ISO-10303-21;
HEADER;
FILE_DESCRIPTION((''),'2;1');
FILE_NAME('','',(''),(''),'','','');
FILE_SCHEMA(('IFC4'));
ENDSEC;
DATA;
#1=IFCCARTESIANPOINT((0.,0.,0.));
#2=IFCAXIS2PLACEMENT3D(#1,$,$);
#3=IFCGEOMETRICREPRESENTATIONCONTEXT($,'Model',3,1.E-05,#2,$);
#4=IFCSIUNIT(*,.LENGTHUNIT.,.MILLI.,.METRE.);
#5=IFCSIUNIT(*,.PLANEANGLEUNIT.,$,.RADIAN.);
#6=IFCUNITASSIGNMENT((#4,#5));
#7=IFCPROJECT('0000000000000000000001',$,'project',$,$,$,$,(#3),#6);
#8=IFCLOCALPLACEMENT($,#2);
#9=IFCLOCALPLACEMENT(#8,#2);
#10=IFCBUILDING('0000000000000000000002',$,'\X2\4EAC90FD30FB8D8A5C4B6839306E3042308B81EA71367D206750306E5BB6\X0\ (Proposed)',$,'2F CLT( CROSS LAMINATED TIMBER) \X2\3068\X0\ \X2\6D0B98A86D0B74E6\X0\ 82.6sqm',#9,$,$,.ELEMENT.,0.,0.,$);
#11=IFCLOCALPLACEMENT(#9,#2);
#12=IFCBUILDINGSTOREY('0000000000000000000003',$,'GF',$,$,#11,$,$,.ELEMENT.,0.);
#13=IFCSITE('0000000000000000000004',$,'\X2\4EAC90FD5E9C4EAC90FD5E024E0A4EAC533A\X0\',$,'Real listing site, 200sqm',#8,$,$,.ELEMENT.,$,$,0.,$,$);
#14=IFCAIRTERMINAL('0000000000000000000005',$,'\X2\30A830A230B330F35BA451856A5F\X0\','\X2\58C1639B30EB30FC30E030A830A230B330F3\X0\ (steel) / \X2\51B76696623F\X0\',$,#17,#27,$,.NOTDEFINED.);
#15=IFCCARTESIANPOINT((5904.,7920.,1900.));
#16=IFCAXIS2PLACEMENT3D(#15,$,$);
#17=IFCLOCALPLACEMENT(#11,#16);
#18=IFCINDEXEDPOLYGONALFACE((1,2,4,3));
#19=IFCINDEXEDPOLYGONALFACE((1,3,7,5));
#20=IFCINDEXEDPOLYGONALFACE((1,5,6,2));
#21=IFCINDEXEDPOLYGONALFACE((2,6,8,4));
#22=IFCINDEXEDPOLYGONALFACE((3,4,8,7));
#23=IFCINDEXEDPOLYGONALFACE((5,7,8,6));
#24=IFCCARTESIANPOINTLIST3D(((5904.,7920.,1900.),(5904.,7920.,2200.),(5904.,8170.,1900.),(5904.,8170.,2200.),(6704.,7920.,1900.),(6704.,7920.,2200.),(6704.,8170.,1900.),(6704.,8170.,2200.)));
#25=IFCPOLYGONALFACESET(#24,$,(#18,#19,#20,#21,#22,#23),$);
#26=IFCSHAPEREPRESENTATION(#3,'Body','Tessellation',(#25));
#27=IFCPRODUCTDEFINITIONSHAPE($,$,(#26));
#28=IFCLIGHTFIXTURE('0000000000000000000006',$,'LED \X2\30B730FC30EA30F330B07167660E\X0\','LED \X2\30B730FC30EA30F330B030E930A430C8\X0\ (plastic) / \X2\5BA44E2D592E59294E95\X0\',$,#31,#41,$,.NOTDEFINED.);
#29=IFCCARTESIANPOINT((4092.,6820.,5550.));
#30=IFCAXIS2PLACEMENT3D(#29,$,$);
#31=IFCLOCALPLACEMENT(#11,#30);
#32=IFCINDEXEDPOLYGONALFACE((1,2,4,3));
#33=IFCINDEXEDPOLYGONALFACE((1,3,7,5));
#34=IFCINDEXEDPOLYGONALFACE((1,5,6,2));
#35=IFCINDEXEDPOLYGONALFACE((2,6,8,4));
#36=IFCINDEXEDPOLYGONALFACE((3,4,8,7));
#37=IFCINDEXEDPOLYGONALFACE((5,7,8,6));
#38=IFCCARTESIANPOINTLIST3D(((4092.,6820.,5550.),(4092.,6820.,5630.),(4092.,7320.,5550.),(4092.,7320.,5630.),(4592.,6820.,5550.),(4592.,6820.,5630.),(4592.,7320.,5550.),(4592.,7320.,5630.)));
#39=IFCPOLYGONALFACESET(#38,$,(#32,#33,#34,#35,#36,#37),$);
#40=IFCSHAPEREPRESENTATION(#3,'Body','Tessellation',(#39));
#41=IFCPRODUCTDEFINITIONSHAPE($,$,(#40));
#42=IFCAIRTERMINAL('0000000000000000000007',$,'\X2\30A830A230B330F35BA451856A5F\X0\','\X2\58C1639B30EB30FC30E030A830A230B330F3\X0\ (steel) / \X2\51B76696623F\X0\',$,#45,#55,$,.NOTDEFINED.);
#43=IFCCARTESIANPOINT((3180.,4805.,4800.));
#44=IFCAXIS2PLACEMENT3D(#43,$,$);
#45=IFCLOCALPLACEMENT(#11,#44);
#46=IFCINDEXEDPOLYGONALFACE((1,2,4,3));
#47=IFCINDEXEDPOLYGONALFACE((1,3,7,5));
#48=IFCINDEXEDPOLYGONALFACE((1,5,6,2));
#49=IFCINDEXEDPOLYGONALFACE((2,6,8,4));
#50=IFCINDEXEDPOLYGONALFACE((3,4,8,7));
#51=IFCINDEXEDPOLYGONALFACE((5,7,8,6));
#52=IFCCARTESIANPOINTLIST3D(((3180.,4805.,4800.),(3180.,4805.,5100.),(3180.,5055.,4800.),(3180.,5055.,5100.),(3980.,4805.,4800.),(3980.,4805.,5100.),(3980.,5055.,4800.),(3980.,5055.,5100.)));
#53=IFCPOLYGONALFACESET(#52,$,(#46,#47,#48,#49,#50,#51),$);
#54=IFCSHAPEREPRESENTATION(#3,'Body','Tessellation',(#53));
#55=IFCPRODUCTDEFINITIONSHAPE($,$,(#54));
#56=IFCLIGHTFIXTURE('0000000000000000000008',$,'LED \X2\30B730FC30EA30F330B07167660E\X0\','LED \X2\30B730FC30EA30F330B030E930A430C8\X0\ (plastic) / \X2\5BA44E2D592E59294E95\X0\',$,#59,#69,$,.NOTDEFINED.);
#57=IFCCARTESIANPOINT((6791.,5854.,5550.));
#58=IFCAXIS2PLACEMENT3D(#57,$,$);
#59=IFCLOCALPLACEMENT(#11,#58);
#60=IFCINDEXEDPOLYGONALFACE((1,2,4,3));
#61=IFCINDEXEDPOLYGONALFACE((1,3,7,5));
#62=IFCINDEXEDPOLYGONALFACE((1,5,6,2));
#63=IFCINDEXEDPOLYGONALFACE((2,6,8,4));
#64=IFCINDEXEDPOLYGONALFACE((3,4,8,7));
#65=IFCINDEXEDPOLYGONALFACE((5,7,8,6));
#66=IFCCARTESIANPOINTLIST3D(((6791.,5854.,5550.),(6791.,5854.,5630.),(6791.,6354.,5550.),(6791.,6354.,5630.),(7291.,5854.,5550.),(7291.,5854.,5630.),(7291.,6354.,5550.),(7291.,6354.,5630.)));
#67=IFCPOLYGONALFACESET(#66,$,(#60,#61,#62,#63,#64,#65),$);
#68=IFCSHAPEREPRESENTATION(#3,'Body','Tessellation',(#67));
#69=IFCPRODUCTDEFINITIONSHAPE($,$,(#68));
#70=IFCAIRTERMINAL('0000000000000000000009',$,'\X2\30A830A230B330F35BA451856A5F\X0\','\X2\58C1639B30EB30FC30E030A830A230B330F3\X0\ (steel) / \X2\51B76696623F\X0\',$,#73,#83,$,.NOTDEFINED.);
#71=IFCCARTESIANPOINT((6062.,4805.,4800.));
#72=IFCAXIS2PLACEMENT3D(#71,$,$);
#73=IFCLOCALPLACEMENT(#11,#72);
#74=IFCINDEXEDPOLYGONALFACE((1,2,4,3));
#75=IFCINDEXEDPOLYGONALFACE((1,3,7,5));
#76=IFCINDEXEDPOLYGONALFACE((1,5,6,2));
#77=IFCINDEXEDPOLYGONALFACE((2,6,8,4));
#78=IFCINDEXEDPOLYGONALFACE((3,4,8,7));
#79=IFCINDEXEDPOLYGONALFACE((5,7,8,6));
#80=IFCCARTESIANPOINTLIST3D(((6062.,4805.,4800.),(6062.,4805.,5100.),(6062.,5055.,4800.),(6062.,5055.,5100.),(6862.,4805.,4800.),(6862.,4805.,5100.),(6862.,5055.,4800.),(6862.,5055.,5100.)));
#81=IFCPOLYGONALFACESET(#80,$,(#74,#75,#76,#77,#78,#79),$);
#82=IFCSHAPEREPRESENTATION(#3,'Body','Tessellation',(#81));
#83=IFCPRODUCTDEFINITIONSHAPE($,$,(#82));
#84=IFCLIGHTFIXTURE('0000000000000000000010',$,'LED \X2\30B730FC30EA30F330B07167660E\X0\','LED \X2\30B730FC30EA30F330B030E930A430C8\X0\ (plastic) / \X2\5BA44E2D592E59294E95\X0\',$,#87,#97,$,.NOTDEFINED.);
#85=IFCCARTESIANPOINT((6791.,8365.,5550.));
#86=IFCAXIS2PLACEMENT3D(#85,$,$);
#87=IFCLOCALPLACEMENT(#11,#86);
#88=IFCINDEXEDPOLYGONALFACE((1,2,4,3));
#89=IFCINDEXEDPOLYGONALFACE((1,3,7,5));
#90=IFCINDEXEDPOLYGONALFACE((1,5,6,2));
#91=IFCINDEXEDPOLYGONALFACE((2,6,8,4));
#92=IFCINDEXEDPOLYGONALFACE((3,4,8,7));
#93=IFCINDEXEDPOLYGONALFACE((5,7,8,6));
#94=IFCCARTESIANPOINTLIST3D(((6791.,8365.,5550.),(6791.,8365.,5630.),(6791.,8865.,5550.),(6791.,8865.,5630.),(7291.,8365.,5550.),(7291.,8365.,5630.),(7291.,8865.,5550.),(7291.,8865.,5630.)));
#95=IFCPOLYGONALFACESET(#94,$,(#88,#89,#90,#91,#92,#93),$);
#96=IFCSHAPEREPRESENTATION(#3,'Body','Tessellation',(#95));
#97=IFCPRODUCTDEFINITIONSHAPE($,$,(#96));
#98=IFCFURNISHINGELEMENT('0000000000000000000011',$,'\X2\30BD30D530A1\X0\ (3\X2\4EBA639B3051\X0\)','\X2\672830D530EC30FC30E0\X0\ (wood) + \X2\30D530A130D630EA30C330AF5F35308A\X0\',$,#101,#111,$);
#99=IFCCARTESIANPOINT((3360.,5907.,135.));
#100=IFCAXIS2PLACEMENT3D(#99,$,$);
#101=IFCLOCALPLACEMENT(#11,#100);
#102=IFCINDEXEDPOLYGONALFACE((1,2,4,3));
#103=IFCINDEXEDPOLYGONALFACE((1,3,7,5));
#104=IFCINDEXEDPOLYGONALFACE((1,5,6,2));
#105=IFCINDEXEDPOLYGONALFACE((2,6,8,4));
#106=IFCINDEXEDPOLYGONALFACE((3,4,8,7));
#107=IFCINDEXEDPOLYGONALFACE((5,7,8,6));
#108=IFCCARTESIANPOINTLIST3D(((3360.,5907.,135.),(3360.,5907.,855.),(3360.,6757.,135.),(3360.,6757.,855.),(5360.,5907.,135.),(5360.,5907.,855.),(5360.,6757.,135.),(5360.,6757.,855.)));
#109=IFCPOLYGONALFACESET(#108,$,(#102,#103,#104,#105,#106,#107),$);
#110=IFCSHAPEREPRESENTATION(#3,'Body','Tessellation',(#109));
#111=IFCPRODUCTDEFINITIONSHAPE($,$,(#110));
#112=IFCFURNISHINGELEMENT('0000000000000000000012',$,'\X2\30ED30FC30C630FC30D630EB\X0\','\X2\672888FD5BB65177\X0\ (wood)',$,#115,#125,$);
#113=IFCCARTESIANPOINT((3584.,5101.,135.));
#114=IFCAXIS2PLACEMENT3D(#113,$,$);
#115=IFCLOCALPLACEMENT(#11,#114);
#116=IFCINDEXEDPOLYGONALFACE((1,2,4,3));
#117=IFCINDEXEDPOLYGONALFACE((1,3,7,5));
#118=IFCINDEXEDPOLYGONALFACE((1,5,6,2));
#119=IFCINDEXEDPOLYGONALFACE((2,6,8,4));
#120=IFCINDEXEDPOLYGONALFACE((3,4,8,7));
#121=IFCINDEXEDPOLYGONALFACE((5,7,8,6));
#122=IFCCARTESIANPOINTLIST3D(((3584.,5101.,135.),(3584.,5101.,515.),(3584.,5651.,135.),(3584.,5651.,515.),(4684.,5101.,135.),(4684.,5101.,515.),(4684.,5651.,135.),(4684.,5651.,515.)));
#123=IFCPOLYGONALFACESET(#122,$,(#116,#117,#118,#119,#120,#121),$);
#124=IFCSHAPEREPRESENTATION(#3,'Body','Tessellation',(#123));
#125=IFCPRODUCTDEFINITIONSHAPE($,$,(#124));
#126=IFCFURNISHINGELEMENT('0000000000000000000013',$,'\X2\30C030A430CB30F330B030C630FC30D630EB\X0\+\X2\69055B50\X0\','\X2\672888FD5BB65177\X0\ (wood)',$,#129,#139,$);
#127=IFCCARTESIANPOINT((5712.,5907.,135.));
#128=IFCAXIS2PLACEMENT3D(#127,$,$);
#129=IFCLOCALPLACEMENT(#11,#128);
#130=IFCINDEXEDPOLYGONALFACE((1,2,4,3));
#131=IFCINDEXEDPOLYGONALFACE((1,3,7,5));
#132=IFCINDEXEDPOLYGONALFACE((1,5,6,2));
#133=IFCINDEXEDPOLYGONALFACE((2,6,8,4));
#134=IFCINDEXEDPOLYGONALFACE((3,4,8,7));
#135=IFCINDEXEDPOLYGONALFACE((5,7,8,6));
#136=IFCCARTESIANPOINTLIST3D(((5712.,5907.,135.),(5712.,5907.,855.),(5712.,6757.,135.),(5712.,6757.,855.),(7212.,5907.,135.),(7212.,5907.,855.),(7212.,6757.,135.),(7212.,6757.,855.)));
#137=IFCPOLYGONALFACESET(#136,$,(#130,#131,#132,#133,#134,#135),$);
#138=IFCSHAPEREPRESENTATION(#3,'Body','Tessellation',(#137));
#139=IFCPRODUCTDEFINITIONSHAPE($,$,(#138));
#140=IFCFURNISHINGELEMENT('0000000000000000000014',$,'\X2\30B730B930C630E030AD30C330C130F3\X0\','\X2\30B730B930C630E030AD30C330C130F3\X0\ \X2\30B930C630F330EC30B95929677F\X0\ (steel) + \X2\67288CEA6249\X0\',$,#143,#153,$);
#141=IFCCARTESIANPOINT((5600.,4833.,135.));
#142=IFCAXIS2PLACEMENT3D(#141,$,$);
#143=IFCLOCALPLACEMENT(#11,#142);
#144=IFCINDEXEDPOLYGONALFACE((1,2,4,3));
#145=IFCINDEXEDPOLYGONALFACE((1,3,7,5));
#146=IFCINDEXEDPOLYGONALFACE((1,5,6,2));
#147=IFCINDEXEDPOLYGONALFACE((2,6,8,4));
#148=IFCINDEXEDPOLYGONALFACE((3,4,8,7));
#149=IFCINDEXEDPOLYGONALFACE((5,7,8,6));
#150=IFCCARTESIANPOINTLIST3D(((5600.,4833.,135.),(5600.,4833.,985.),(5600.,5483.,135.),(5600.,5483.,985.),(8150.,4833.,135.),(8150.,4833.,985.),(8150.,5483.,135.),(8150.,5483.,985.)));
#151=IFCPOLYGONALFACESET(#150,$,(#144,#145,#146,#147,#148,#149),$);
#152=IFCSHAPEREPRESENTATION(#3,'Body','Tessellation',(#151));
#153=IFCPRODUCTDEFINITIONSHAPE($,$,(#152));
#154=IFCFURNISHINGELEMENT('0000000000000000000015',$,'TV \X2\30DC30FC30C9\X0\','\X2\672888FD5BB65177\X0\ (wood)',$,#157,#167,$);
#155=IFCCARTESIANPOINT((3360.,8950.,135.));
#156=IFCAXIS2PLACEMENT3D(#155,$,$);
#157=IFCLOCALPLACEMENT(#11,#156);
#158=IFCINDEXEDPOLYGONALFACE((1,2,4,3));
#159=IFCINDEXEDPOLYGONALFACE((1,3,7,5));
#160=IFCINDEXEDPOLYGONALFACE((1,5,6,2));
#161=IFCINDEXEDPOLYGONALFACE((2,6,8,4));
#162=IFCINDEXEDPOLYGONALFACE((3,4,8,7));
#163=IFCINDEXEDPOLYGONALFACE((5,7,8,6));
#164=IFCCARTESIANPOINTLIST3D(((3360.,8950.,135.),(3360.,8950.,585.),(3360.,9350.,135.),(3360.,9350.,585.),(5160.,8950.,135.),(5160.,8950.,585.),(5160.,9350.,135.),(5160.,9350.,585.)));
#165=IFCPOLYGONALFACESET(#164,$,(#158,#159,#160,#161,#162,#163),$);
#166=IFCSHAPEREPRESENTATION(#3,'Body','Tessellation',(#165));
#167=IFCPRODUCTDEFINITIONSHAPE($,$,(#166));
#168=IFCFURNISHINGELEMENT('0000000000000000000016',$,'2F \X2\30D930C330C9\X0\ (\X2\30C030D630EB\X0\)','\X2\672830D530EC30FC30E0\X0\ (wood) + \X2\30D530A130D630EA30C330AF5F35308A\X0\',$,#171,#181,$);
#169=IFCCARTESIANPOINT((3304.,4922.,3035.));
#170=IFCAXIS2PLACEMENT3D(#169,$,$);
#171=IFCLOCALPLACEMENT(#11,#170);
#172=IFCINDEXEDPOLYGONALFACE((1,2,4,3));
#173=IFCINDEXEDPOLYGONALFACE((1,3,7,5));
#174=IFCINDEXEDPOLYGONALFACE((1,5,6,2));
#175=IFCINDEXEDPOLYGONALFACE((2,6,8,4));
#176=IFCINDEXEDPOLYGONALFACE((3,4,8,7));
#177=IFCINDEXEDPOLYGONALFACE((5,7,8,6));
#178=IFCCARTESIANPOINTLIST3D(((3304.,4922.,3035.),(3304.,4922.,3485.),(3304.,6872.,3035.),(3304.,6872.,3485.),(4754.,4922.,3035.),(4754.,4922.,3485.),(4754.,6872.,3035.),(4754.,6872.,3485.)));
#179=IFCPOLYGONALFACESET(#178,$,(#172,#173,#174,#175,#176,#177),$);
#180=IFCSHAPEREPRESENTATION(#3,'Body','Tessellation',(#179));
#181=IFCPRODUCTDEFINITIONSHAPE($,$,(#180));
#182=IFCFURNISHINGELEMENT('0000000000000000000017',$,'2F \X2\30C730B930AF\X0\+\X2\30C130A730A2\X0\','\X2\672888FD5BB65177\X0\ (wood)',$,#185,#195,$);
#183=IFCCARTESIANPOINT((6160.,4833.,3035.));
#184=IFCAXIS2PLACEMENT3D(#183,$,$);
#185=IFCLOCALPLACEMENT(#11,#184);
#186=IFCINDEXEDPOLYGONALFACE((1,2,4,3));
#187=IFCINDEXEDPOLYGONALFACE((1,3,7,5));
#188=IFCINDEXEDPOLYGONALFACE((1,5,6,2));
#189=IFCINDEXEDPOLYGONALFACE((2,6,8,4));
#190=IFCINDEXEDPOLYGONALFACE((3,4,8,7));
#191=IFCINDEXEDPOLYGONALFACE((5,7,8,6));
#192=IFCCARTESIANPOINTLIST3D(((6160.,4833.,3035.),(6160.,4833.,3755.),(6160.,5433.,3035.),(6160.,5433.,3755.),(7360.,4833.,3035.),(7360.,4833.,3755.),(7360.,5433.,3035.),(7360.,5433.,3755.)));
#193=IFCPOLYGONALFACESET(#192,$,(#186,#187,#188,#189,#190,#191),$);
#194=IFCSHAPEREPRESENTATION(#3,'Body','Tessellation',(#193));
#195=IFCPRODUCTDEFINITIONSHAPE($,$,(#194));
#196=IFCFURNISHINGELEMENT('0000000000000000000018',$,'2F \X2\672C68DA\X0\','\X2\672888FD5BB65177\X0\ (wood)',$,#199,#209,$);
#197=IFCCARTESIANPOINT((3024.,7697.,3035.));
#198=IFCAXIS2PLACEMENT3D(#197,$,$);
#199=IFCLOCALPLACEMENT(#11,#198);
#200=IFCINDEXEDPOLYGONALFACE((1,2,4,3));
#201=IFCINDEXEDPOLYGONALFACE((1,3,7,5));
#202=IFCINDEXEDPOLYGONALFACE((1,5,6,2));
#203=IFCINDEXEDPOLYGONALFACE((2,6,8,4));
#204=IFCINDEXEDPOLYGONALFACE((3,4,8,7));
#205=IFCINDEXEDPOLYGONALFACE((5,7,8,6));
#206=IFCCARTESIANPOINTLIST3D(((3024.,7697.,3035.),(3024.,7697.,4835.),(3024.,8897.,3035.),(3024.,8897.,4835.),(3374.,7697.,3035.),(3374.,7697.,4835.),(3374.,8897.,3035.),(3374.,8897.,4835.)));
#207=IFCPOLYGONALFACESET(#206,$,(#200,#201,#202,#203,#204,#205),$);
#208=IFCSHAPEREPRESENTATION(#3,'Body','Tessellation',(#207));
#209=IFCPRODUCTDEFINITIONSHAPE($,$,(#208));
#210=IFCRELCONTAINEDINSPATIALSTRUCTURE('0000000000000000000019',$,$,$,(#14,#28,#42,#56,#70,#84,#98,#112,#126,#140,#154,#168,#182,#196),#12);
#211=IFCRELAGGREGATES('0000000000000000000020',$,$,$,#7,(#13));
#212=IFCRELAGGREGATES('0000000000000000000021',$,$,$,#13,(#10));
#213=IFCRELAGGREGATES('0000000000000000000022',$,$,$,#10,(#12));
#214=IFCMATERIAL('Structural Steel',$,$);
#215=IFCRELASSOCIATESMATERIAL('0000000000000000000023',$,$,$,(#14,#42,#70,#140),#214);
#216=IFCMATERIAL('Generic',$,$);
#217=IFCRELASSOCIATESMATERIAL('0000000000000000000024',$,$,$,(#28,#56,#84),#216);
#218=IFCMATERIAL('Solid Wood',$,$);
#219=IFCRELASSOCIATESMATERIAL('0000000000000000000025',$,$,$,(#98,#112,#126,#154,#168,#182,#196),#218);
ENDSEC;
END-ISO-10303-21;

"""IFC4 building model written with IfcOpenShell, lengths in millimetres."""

from ifc_helpers import new_model, si_unit, frame, frame_2d, origin, place, context, project, spatial, rectangle, extrude, material, element, save


model = new_model("IFC4")

# Units and contexts
model_context = context("Model", 3, precision=1e-05, world=origin())
ifc_project = project(units=[si_unit("LENGTHUNIT", "METRE", prefix="MILLI"), si_unit("PLANEANGLEUNIT", "RADIAN")], contexts=[model_context])

# Site, building, storey
site_placement = place(None, origin())
site = spatial("IfcSite", under=ifc_project, at=site_placement, Name="京都府京都市上京区", ObjectType="Real listing site, 200sqm", CompositionType="ELEMENT", RefElevation=0.0)
building_placement = place(site_placement, origin())
building = spatial("IfcBuilding", under=site, at=building_placement, Name="京都・越屋根のある自然素材の家 (Proposed)", ObjectType="2F CLT( CROSS LAMINATED TIMBER) と 洋風洋瓦 82.6sqm", CompositionType="ELEMENT", ElevationOfRefHeight=0.0, ElevationOfTerrain=0.0)
storey_placement = place(building_placement, origin())
storey = spatial("IfcBuildingStorey", under=building, at=storey_placement, Name="GF", CompositionType="ELEMENT", Elevation=0.0)

# Shared definitions
ifc_material_1 = material(Name="Solid Wood")

# Shared definitions
ifc_material_2 = material(Name="Structural Steel")

# Shared definitions
ifc_material_3 = material(Name="Generic")

# Air terminal
air_terminal_1_placement = place(storey_placement, frame((5904.0, 7920.0, 1900.0)))
element("IfcAirTerminal", 1, at=air_terminal_1_placement, inside=storey, material=ifc_material_2, Name="エアコン室内機", Description="壁掛ルームエアコン (steel) / 冷暖房", PredefinedType="NOTDEFINED", context=model_context, shape_type="SweptSolid", body=[
    extrude(rectangle(XDim=800.0, YDim=250.0, at=frame_2d((400.0, 125.0))), frame((5904.0, 7920.0, 1900.0)), (0.0, 0.0, 1.0), 300.0),
])

# Light fixture
light_fixture_1_placement = place(storey_placement, frame((4092.0, 6820.0, 5550.0)))
element("IfcLightFixture", 2, at=light_fixture_1_placement, inside=storey, material=ifc_material_3, Name="LED シーリング照明", Description="LED シーリングライト (plastic) / 室中央天井", PredefinedType="NOTDEFINED", context=model_context, shape_type="SweptSolid", body=[
    extrude(rectangle(XDim=500.0, YDim=500.0, at=frame_2d((250.0, 250.0))), frame((4092.0, 6820.0, 5550.0)), (0.0, 0.0, 1.0), 80.0),
])

# Air terminal
air_terminal_2_placement = place(storey_placement, frame((3180.0, 4805.0, 4800.0)))
element("IfcAirTerminal", 3, at=air_terminal_2_placement, inside=storey, material=ifc_material_2, Name="エアコン室内機", Description="壁掛ルームエアコン (steel) / 冷暖房", PredefinedType="NOTDEFINED", context=model_context, shape_type="SweptSolid", body=[
    extrude(rectangle(XDim=800.0, YDim=250.0, at=frame_2d((400.0, 125.0))), frame((3180.0, 4805.0, 4800.0)), (0.0, 0.0, 1.0), 300.0),
])

# Light fixture
light_fixture_2_placement = place(storey_placement, frame((6791.0, 5854.0, 5550.0)))
element("IfcLightFixture", 4, at=light_fixture_2_placement, inside=storey, material=ifc_material_3, Name="LED シーリング照明", Description="LED シーリングライト (plastic) / 室中央天井", PredefinedType="NOTDEFINED", context=model_context, shape_type="SweptSolid", body=[
    extrude(rectangle(XDim=500.0, YDim=500.0, at=frame_2d((250.0, 250.0))), frame((6791.0, 5854.0, 5550.0)), (0.0, 0.0, 1.0), 80.0),
])

# Air terminal
air_terminal_3_placement = place(storey_placement, frame((6062.0, 4805.0, 4800.0)))
element("IfcAirTerminal", 5, at=air_terminal_3_placement, inside=storey, material=ifc_material_2, Name="エアコン室内機", Description="壁掛ルームエアコン (steel) / 冷暖房", PredefinedType="NOTDEFINED", context=model_context, shape_type="SweptSolid", body=[
    extrude(rectangle(XDim=800.0, YDim=250.0, at=frame_2d((400.0, 125.0))), frame((6062.0, 4805.0, 4800.0)), (0.0, 0.0, 1.0), 300.0),
])

# Light fixture
light_fixture_3_placement = place(storey_placement, frame((6791.0, 8365.0, 5550.0)))
element("IfcLightFixture", 6, at=light_fixture_3_placement, inside=storey, material=ifc_material_3, Name="LED シーリング照明", Description="LED シーリングライト (plastic) / 室中央天井", PredefinedType="NOTDEFINED", context=model_context, shape_type="SweptSolid", body=[
    extrude(rectangle(XDim=500.0, YDim=500.0, at=frame_2d((250.0, 250.0))), frame((6791.0, 8365.0, 5550.0)), (0.0, 0.0, 1.0), 80.0),
])

# Furnishing elements
furnishing_1_placement = place(storey_placement, frame((3360.0, 5907.0, 135.0)))
element("IfcFurnishingElement", 7, at=furnishing_1_placement, inside=storey, material=ifc_material_1, Name="ソファ (3人掛け)", Description="木フレーム (wood) + ファブリック張り", context=model_context, shape_type="SweptSolid", body=[
    extrude(rectangle(XDim=2000.0, YDim=850.0, at=frame_2d((1000.0, 425.0))), frame((3360.0, 5907.0, 135.0)), (0.0, 0.0, 1.0), 720.0),
])
furnishing_2_placement = place(storey_placement, frame((3584.0, 5101.0, 135.0)))
element("IfcFurnishingElement", 8, at=furnishing_2_placement, inside=storey, material=ifc_material_1, Name="ローテーブル", Description="木製家具 (wood)", context=model_context, shape_type="SweptSolid", body=[
    extrude(rectangle(XDim=1100.0, YDim=550.0, at=frame_2d((550.0, 275.0))), frame((3584.0, 5101.0, 135.0)), (0.0, 0.0, 1.0), 380.0),
])
furnishing_3_placement = place(storey_placement, frame((5712.0, 5907.0, 135.0)))
element("IfcFurnishingElement", 9, at=furnishing_3_placement, inside=storey, material=ifc_material_1, Name="ダイニングテーブル+椅子", Description="木製家具 (wood)", context=model_context, shape_type="SweptSolid", body=[
    extrude(rectangle(XDim=1500.0, YDim=850.0, at=frame_2d((750.0, 425.0))), frame((5712.0, 5907.0, 135.0)), (0.0, 0.0, 1.0), 720.0),
])
furnishing_4_placement = place(storey_placement, frame((5600.0, 4833.0, 135.0)))
element("IfcFurnishingElement", 10, at=furnishing_4_placement, inside=storey, material=ifc_material_2, Name="システムキッチン", Description="システムキッチン ステンレス天板 (steel) + 木質扉", context=model_context, shape_type="SweptSolid", body=[
    extrude(rectangle(XDim=2550.0, YDim=650.0, at=frame_2d((1275.0, 325.0))), frame((5600.0, 4833.0, 135.0)), (0.0, 0.0, 1.0), 850.0),
])
furnishing_5_placement = place(storey_placement, frame((3360.0, 8950.0, 135.0)))
element("IfcFurnishingElement", 11, at=furnishing_5_placement, inside=storey, material=ifc_material_1, Name="TV ボード", Description="木製家具 (wood)", context=model_context, shape_type="SweptSolid", body=[
    extrude(rectangle(XDim=1800.0, YDim=400.0, at=frame_2d((900.0, 200.0))), frame((3360.0, 8950.0, 135.0)), (0.0, 0.0, 1.0), 450.0),
])
furnishing_6_placement = place(storey_placement, frame((3304.0, 4922.0, 3035.0)))
element("IfcFurnishingElement", 12, at=furnishing_6_placement, inside=storey, material=ifc_material_1, Name="2F ベッド (ダブル)", Description="木フレーム (wood) + ファブリック張り", context=model_context, shape_type="SweptSolid", body=[
    extrude(rectangle(XDim=1450.0, YDim=1950.0, at=frame_2d((725.0, 975.0))), frame((3304.0, 4922.0, 3035.0)), (0.0, 0.0, 1.0), 450.0),
])
furnishing_7_placement = place(storey_placement, frame((6160.0, 4833.0, 3035.0)))
element("IfcFurnishingElement", 13, at=furnishing_7_placement, inside=storey, material=ifc_material_1, Name="2F デスク+チェア", Description="木製家具 (wood)", context=model_context, shape_type="SweptSolid", body=[
    extrude(rectangle(XDim=1200.0, YDim=600.0, at=frame_2d((600.0, 300.0))), frame((6160.0, 4833.0, 3035.0)), (0.0, 0.0, 1.0), 720.0),
])
furnishing_8_placement = place(storey_placement, frame((3024.0, 7697.0, 3035.0)))
element("IfcFurnishingElement", 14, at=furnishing_8_placement, inside=storey, material=ifc_material_1, Name="2F 本棚", Description="木製家具 (wood)", context=model_context, shape_type="SweptSolid", body=[
    extrude(rectangle(XDim=350.0, YDim=1200.0, at=frame_2d((175.0, 600.0))), frame((3024.0, 7697.0, 3035.0)), (0.0, 0.0, 1.0), 1800.0),
])

save(model, "model.ifc")
